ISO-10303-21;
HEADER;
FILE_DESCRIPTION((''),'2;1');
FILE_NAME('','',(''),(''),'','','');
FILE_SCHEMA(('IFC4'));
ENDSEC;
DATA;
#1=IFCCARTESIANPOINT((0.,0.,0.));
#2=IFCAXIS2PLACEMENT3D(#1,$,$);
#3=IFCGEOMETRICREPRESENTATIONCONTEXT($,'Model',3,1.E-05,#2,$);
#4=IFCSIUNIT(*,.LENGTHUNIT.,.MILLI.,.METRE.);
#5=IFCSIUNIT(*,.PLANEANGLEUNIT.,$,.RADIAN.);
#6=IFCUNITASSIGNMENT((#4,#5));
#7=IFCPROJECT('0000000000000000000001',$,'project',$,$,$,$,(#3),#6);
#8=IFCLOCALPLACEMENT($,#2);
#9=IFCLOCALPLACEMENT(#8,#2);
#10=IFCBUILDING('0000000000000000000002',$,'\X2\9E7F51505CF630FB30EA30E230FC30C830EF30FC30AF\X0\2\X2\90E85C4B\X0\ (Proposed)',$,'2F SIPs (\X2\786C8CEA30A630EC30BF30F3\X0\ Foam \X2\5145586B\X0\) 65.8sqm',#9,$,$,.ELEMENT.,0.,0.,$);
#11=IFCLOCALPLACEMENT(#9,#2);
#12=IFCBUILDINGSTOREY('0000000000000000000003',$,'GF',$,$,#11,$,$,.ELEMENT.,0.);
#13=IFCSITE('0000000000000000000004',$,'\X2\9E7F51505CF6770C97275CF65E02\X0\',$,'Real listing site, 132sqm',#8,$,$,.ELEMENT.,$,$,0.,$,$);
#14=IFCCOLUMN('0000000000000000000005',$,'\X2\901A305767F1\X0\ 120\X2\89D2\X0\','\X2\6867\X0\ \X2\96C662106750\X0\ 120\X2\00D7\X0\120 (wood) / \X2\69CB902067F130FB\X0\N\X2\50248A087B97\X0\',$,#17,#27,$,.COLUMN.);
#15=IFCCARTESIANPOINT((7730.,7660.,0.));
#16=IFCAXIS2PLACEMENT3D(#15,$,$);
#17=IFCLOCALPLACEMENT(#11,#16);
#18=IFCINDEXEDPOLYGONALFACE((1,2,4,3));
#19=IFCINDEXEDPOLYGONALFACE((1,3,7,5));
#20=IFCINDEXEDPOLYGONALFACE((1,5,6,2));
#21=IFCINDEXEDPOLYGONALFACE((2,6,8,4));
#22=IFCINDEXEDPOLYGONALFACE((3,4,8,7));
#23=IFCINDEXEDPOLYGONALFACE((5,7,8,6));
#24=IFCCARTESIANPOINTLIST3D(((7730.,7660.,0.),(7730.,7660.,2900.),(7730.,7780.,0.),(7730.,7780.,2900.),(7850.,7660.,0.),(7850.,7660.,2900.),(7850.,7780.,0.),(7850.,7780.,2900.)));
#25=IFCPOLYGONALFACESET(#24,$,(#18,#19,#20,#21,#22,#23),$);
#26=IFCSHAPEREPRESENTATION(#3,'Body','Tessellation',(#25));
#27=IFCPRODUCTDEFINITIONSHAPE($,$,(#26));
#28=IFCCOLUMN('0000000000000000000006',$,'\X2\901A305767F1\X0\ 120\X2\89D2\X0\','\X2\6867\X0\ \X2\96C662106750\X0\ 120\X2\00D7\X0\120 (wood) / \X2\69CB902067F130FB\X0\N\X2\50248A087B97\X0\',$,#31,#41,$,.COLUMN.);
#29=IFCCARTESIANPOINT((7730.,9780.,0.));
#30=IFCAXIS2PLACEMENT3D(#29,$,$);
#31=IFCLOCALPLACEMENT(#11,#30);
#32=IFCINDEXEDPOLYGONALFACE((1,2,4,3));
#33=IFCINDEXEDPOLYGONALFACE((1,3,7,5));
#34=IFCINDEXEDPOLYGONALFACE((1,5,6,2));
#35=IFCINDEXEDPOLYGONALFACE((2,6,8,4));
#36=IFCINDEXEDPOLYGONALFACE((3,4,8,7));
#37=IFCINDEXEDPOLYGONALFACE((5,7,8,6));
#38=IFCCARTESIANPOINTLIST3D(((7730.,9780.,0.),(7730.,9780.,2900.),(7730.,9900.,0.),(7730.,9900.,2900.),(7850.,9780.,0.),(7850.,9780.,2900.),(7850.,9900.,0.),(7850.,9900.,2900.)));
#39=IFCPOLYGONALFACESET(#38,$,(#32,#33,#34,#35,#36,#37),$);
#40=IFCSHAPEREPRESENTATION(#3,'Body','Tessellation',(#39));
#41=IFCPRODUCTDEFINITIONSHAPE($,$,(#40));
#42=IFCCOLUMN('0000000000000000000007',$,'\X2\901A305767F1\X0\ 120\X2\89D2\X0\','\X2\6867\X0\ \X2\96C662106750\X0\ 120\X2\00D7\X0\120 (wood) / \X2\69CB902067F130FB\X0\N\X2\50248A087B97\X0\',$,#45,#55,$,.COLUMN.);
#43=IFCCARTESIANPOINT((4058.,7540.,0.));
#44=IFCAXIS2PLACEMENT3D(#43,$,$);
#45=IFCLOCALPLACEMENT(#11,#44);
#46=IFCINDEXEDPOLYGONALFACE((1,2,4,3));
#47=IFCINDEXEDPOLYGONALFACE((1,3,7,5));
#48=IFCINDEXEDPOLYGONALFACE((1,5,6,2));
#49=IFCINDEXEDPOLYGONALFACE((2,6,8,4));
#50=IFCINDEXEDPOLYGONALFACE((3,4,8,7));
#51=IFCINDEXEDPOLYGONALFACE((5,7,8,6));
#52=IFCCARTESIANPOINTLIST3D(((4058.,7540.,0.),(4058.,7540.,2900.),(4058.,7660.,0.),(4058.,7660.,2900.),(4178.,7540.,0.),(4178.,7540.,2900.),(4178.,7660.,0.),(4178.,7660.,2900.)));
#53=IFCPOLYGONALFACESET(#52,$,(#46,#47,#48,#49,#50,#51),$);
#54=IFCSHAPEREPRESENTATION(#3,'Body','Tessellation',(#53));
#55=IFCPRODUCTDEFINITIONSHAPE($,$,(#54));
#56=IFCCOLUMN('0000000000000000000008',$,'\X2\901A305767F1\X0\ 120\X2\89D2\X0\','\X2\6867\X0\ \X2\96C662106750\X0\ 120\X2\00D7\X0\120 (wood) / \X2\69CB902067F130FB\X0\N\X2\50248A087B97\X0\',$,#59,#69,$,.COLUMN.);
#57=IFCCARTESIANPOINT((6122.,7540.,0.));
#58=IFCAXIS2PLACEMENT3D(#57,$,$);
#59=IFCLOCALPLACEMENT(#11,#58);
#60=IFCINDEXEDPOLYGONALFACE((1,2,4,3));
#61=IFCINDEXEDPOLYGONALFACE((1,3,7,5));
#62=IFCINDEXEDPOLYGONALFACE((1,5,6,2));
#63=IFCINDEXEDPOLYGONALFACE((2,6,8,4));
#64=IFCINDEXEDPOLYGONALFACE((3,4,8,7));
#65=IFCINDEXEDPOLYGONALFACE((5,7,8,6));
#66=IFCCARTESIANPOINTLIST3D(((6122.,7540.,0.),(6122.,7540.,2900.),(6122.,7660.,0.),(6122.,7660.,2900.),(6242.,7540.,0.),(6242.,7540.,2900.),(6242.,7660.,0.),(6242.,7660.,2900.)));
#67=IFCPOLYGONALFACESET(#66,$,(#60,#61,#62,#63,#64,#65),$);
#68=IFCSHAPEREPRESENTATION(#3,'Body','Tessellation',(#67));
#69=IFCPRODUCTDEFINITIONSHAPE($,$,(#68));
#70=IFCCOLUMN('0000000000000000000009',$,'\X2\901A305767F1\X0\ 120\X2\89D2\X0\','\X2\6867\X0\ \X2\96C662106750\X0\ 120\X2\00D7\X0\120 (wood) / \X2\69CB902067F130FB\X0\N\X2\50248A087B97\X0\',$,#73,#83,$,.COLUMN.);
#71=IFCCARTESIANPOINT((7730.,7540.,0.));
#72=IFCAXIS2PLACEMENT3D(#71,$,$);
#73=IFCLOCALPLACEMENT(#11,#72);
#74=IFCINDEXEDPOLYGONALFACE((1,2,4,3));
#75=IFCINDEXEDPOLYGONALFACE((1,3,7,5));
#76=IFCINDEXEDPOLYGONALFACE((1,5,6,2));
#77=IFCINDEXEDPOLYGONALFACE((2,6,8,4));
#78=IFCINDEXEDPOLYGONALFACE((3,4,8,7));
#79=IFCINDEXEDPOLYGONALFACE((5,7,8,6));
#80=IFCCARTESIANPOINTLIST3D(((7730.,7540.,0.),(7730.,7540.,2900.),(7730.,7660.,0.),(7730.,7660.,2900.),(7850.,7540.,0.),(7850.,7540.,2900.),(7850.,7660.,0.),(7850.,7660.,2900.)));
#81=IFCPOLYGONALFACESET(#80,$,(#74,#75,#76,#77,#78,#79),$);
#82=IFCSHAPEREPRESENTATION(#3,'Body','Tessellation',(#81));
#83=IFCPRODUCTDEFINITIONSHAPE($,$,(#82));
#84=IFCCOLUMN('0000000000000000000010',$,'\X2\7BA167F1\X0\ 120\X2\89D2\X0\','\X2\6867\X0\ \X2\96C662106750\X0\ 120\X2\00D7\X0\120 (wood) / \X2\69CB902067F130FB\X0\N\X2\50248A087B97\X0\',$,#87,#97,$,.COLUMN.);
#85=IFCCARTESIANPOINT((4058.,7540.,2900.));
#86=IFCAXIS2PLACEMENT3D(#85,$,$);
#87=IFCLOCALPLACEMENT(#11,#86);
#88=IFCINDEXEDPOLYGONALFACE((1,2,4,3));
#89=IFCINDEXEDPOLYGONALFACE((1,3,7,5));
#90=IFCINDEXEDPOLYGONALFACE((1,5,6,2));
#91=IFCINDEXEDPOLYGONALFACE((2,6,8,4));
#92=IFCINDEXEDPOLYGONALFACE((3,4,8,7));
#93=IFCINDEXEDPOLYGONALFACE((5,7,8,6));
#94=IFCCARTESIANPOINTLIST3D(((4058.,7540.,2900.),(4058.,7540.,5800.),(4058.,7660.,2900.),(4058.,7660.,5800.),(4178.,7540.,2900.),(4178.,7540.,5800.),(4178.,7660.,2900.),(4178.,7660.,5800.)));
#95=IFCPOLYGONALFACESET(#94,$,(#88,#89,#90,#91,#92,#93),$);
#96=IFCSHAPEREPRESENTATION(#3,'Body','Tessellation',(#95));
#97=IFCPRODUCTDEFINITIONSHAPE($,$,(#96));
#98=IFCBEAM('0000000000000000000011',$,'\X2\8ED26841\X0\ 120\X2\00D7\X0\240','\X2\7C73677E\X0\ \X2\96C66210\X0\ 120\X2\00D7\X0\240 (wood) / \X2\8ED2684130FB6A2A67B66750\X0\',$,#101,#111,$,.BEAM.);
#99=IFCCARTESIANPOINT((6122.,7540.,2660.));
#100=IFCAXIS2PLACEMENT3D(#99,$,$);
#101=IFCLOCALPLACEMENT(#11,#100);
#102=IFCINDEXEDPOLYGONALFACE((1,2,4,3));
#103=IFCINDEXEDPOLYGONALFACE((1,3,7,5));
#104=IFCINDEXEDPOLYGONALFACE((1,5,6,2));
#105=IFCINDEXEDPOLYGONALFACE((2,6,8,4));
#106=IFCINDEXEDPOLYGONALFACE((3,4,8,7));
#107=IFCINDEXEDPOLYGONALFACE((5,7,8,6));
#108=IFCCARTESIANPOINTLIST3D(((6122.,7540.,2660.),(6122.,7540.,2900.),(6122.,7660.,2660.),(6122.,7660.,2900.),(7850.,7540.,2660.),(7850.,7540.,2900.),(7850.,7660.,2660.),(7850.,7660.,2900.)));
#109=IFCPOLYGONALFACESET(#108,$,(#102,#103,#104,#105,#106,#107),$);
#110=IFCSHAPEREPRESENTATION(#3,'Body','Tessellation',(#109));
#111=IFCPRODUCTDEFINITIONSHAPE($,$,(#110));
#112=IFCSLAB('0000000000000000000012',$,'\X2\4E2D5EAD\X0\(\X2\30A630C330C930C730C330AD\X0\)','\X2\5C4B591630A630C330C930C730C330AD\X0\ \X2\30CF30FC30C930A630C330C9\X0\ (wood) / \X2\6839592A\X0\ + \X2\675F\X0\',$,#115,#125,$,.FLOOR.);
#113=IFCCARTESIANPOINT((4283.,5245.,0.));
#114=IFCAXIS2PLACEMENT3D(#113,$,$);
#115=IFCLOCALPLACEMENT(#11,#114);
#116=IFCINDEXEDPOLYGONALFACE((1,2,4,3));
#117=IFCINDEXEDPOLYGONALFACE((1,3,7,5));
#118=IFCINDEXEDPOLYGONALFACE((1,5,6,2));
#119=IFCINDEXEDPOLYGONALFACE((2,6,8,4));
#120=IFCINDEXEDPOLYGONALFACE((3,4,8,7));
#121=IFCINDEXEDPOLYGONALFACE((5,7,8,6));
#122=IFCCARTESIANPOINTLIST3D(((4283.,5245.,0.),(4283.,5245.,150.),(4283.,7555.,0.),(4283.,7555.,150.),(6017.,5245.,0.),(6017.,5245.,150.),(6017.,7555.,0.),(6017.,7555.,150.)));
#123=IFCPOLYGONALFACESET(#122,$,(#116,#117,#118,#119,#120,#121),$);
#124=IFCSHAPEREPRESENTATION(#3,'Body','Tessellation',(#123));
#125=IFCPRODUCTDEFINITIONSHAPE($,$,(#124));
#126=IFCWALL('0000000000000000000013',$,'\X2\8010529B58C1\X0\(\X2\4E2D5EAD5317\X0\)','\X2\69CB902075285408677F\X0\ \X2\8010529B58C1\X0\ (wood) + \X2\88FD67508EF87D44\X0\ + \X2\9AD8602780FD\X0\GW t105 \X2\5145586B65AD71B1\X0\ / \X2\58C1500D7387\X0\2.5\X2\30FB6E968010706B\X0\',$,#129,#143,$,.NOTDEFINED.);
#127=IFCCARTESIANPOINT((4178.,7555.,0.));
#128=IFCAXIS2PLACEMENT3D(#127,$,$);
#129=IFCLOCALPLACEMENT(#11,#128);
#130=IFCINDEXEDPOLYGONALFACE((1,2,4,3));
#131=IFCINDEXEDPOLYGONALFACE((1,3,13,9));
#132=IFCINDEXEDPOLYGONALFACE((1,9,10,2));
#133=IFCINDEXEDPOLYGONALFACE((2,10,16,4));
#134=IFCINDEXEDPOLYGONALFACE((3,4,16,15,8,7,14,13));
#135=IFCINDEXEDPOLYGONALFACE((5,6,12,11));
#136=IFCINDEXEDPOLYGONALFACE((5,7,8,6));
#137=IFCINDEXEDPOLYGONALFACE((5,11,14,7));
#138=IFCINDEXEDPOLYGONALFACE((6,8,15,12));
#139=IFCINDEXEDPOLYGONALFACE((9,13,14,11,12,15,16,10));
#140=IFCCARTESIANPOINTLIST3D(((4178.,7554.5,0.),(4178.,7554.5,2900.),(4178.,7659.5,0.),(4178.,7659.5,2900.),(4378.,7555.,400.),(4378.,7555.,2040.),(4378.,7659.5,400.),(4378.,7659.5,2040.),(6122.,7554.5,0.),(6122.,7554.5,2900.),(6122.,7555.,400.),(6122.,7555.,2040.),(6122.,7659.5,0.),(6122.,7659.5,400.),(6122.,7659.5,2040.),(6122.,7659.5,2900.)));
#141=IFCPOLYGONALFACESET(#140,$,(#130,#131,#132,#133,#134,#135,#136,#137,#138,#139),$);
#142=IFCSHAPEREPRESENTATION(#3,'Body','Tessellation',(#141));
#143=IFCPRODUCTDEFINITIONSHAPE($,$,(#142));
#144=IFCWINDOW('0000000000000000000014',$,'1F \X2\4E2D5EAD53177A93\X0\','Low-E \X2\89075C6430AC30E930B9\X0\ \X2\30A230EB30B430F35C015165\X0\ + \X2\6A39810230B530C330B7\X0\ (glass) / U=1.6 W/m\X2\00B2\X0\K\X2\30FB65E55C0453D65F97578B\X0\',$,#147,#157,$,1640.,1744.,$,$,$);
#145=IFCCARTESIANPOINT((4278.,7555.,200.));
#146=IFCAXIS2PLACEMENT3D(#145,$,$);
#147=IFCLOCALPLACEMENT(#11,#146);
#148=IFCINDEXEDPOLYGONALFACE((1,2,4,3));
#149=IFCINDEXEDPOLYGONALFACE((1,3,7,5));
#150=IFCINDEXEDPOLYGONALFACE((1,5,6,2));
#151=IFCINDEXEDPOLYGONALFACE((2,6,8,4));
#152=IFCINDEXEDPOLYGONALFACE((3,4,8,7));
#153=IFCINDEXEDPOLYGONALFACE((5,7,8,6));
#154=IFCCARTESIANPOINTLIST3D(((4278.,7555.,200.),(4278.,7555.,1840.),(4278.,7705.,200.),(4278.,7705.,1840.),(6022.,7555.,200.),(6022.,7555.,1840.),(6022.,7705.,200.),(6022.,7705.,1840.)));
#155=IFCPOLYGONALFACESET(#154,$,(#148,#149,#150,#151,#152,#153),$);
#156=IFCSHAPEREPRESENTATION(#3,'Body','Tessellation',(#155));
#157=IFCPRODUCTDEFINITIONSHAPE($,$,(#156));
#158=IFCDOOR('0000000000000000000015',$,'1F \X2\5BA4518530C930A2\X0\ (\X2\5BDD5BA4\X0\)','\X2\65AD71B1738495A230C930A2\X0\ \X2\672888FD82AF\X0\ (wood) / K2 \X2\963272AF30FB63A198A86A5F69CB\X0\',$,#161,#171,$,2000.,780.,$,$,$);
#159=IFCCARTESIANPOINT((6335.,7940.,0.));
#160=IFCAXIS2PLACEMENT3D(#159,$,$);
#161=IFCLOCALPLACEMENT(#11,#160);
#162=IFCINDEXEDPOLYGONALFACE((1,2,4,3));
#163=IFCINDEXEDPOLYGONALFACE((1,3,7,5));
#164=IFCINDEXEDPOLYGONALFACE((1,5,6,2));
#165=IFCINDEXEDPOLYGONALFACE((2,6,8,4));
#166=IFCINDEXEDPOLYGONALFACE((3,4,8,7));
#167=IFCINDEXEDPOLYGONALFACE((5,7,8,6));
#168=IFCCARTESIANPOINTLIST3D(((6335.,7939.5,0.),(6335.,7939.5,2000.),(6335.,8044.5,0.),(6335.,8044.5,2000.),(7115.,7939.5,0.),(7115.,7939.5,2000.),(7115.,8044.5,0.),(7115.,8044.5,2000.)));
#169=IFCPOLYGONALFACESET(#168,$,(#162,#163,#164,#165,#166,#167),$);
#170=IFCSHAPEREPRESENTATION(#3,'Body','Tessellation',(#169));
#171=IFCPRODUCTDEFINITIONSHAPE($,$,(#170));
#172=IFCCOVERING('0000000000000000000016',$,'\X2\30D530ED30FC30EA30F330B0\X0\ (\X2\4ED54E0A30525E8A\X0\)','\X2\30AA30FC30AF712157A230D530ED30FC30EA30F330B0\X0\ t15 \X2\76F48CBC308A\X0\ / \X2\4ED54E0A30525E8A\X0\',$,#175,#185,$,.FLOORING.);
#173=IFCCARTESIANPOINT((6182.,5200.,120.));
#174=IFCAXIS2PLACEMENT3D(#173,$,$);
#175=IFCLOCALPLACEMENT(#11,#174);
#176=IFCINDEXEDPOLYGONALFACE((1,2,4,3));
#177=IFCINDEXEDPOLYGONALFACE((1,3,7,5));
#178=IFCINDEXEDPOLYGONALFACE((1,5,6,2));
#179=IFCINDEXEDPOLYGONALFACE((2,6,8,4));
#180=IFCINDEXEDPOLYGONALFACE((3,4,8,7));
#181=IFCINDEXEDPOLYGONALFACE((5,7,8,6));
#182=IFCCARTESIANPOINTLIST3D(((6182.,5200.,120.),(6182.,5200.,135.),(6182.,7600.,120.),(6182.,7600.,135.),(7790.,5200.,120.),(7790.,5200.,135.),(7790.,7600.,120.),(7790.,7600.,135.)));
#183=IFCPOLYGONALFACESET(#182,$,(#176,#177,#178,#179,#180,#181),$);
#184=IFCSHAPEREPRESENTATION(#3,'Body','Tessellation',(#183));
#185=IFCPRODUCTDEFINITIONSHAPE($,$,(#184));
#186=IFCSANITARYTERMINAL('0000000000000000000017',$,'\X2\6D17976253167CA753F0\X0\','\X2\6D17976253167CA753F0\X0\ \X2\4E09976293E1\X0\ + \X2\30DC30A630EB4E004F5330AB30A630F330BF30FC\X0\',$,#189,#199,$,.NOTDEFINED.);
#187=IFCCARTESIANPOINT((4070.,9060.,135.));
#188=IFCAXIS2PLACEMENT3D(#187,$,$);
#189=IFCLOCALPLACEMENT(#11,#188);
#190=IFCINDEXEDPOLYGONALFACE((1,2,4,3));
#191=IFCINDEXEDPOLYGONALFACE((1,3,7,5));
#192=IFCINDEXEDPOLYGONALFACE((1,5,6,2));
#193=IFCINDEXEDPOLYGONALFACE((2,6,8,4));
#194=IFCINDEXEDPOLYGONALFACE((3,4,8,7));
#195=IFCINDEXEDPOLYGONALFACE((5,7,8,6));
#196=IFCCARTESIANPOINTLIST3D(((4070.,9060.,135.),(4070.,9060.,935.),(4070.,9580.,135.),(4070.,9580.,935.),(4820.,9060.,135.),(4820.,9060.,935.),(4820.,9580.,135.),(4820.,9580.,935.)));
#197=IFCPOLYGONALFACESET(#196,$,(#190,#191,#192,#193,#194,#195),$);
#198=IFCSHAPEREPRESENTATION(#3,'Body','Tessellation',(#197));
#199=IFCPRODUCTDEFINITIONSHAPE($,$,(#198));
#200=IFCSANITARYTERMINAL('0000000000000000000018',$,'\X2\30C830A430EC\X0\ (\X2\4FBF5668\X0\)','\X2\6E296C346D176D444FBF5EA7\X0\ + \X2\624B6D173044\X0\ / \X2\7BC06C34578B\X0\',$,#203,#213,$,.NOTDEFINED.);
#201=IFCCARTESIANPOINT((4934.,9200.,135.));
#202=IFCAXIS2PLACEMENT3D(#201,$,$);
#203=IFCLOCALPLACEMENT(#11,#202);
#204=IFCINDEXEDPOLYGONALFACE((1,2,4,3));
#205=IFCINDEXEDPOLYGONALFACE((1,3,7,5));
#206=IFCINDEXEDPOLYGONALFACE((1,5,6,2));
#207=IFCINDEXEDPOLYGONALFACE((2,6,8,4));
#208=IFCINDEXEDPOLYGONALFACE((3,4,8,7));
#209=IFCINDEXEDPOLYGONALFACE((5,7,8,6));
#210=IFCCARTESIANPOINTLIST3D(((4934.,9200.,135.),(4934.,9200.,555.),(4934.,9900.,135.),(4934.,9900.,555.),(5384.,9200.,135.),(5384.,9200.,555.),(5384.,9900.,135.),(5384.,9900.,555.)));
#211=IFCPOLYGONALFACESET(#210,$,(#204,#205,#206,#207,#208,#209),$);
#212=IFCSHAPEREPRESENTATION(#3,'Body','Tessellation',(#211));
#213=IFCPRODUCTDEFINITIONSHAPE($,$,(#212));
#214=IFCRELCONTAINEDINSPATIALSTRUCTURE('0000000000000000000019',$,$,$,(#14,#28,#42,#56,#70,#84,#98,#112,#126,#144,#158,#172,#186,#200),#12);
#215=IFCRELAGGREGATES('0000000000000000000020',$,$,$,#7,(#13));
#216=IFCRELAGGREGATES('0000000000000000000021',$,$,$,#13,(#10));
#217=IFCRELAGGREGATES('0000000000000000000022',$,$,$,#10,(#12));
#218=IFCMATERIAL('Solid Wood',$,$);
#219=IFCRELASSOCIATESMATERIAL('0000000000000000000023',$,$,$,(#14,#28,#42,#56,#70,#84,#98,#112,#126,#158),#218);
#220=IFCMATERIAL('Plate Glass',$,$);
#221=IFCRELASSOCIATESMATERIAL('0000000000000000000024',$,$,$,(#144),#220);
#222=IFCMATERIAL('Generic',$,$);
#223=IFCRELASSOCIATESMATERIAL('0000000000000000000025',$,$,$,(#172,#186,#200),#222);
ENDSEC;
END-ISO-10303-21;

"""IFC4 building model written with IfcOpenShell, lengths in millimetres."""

from ifc_helpers import new_model, si_unit, frame, frame_2d, origin, place, context, project, spatial, rectangle, extrude, material, element, fill, save


model = new_model("IFC4")

# Units and contexts
model_context = context("Model", 3, precision=1e-05, world=origin())
ifc_project = project(units=[si_unit("LENGTHUNIT", "METRE", prefix="MILLI"), si_unit("PLANEANGLEUNIT", "RADIAN")], contexts=[model_context])

# Site, building, storey
site_placement = place(None, origin())
site = spatial("IfcSite", under=ifc_project, at=site_placement, Name="鹿児島県霧島市", ObjectType="Real listing site, 132sqm", CompositionType="ELEMENT", RefElevation=0.0)
building_placement = place(site_placement, origin())
building = spatial("IfcBuilding", under=site, at=building_placement, Name="鹿児島・リモートワーク2部屋 (Proposed)", ObjectType="2F SIPs (硬質ウレタン Foam 充填) 65.8sqm", CompositionType="ELEMENT", ElevationOfRefHeight=0.0, ElevationOfTerrain=0.0)
storey_placement = place(building_placement, origin())
storey = spatial("IfcBuildingStorey", under=building, at=storey_placement, Name="GF", CompositionType="ELEMENT", Elevation=0.0)

# Columns
ifc_material_1 = material(Name="Solid Wood")
column_1_placement = place(storey_placement, frame((7730.0, 7660.0, 0.0)))
element("IfcColumn", 1, at=column_1_placement, inside=storey, material=ifc_material_1, Name="通し柱 120角", Description="桧 集成材 120×120 (wood) / 構造柱・N値計算", PredefinedType="COLUMN", context=model_context, shape_type="SweptSolid", body=[
    extrude(rectangle(XDim=120.0, YDim=120.0, at=frame_2d((60.0, 60.0))), frame((7730.0, 7660.0, 0.0)), (0.0, 0.0, 1.0), 2900.0),
])
column_2_placement = place(storey_placement, frame((7730.0, 9780.0, 0.0)))
element("IfcColumn", 2, at=column_2_placement, inside=storey, material=ifc_material_1, Name="通し柱 120角", Description="桧 集成材 120×120 (wood) / 構造柱・N値計算", PredefinedType="COLUMN", context=model_context, shape_type="SweptSolid", body=[
    extrude(rectangle(XDim=120.0, YDim=120.0, at=frame_2d((60.0, 60.0))), frame((7730.0, 9780.0, 0.0)), (0.0, 0.0, 1.0), 2900.0),
])
column_3_placement = place(storey_placement, frame((4058.0, 7540.0, 0.0)))
element("IfcColumn", 3, at=column_3_placement, inside=storey, material=ifc_material_1, Name="通し柱 120角", Description="桧 集成材 120×120 (wood) / 構造柱・N値計算", PredefinedType="COLUMN", context=model_context, shape_type="SweptSolid", body=[
    extrude(rectangle(XDim=120.0, YDim=120.0, at=frame_2d((60.0, 60.0))), frame((4058.0, 7540.0, 0.0)), (0.0, 0.0, 1.0), 2900.0),
])
column_4_placement = place(storey_placement, frame((6122.0, 7540.0, 0.0)))
element("IfcColumn", 4, at=column_4_placement, inside=storey, material=ifc_material_1, Name="通し柱 120角", Description="桧 集成材 120×120 (wood) / 構造柱・N値計算", PredefinedType="COLUMN", context=model_context, shape_type="SweptSolid", body=[
    extrude(rectangle(XDim=120.0, YDim=120.0, at=frame_2d((60.0, 60.0))), frame((6122.0, 7540.0, 0.0)), (0.0, 0.0, 1.0), 2900.0),
])
column_5_placement = place(storey_placement, frame((7730.0, 7540.0, 0.0)))
element("IfcColumn", 5, at=column_5_placement, inside=storey, material=ifc_material_1, Name="通し柱 120角", Description="桧 集成材 120×120 (wood) / 構造柱・N値計算", PredefinedType="COLUMN", context=model_context, shape_type="SweptSolid", body=[
    extrude(rectangle(XDim=120.0, YDim=120.0, at=frame_2d((60.0, 60.0))), frame((7730.0, 7540.0, 0.0)), (0.0, 0.0, 1.0), 2900.0),
])
column_6_placement = place(storey_placement, frame((4058.0, 7540.0, 2900.0)))
element("IfcColumn", 6, at=column_6_placement, inside=storey, material=ifc_material_1, Name="管柱 120角", Description="桧 集成材 120×120 (wood) / 構造柱・N値計算", PredefinedType="COLUMN", context=model_context, shape_type="SweptSolid", body=[
    extrude(rectangle(XDim=120.0, YDim=120.0, at=frame_2d((60.0, 60.0))), frame((4058.0, 7540.0, 2900.0)), (0.0, 0.0, 1.0), 2900.0),
])

# Beam
beam_1_placement = place(storey_placement, frame((6122.0, 7540.0, 2660.0)))
element("IfcBeam", 7, at=beam_1_placement, inside=storey, material=ifc_material_1, Name="軒桁 120×240", Description="米松 集成 120×240 (wood) / 軒桁・横架材", PredefinedType="BEAM", context=model_context, shape_type="SweptSolid", body=[
    extrude(rectangle(XDim=1728.0, YDim=120.0, at=frame_2d((864.0, 60.0))), frame((6122.0, 7540.0, 2660.0)), (0.0, 0.0, 1.0), 240.0),
])

# Slab
slab_placement = place(storey_placement, frame((4283.0, 5245.0, 0.0)))
element("IfcSlab", 8, at=slab_placement, inside=storey, material=ifc_material_1, Name="中庭(ウッドデッキ)", Description="屋外ウッドデッキ ハードウッド (wood) / 根太 + 束", PredefinedType="FLOOR", context=model_context, shape_type="SweptSolid", body=[
    extrude(rectangle(XDim=1734.0, YDim=2310.0, at=frame_2d((867.0, 1155.0))), frame((4283.0, 5245.0, 0.0)), (0.0, 0.0, 1.0), 150.0),
])

# Wall, opening, window
wall_1_placement = place(storey_placement, frame((4178.0, 7555.0, 0.0)))
wall_1 = element("IfcWall", 9, at=wall_1_placement, inside=storey, material=ifc_material_1, Name="耐力壁(中庭北)", Description="構造用合板 耐力壁 (wood) + 製材軸組 + 高性能GW t105 充填断熱 / 壁倍率2.5・準耐火", PredefinedType="NOTDEFINED", context=model_context, shape_type="SweptSolid", body=[
    extrude(rectangle(XDim=1944.0, YDim=105.0, at=frame_2d((972.0, 52.0))), frame((4178.0, 7555.0, 0.0)), (0.0, 0.0, 1.0), 2900.0),
])
opening_placement = place(storey_placement, frame((4278.0, 7555.0, 200.0)))
opening = element("IfcOpeningElement", 10, at=opening_placement, cuts=wall_1, PredefinedType="NOTDEFINED", context=model_context, shape_type="SweptSolid", body=[
    extrude(rectangle(XDim=1744.0, YDim=150.0, at=frame_2d((872.0, 75.0))), frame((4278.0, 7555.0, 200.0)), (0.0, 0.0, 1.0), 1640.0),
])
ifc_material_2 = material(Name="Plate Glass")
window_placement = place(storey_placement, frame((4278.0, 7555.0, 200.0)))
window = element("IfcWindow", 11, at=window_placement, inside=storey, material=ifc_material_2, Name="1F 中庭北窓", Description="Low-E 複層ガラス アルゴン封入 + 樹脂サッシ (glass) / U=1.6 W/m²K・日射取得型", OverallHeight=1640.0, OverallWidth=1744.0, context=model_context, shape_type="SweptSolid", body=[
    extrude(rectangle(XDim=1744.0, YDim=150.0, at=frame_2d((872.0, 75.0))), frame((4278.0, 7555.0, 200.0)), (0.0, 0.0, 1.0), 1640.0),
])
fill(opening, window)

# Door
door_placement = place(storey_placement, frame((6335.0, 7940.0, 0.0)))
element("IfcDoor", 12, at=door_placement, inside=storey, material=ifc_material_1, Name="1F 室内ドア (寝室)", Description="断熱玄関ドア 木製芯 (wood) / K2 防犯・採風機構", OverallHeight=2000.0, OverallWidth=780.0, context=model_context, shape_type="SweptSolid", body=[
    extrude(rectangle(XDim=780.0, YDim=105.0, at=frame_2d((390.0, 52.0))), frame((6335.0, 7940.0, 0.0)), (0.0, 0.0, 1.0), 2000.0),
])

# Covering
ifc_material_3 = material(Name="Generic")
covering_placement = place(storey_placement, frame((6182.0, 5200.0, 120.0)))
element("IfcCovering", 13, at=covering_placement, inside=storey, material=ifc_material_3, Name="フローリング (仕上げ床)", Description="オーク無垢フローリング t15 直貼り / 仕上げ床", PredefinedType="FLOORING", context=model_context, shape_type="SweptSolid", body=[
    extrude(rectangle(XDim=1608.0, YDim=2400.0, at=frame_2d((804.0, 1200.0))), frame((6182.0, 5200.0, 120.0)), (0.0, 0.0, 1.0), 15.0),
])

# Sanitary terminals
sanitary_terminal_1_placement = place(storey_placement, frame((4070.0, 9060.0, 135.0)))
element("IfcSanitaryTerminal", 14, at=sanitary_terminal_1_placement, inside=storey, material=ifc_material_3, Name="洗面化粧台", Description="洗面化粧台 三面鏡 + ボウル一体カウンター", PredefinedType="NOTDEFINED", context=model_context, shape_type="SweptSolid", body=[
    extrude(rectangle(XDim=750.0, YDim=520.0, at=frame_2d((375.0, 260.0))), frame((4070.0, 9060.0, 135.0)), (0.0, 0.0, 1.0), 800.0),
])
sanitary_terminal_2_placement = place(storey_placement, frame((4934.0, 9200.0, 135.0)))
element("IfcSanitaryTerminal", 15, at=sanitary_terminal_2_placement, inside=storey, material=ifc_material_3, Name="トイレ (便器)", Description="温水洗浄便座 + 手洗い / 節水型", PredefinedType="NOTDEFINED", context=model_context, shape_type="SweptSolid", body=[
    extrude(rectangle(XDim=450.0, YDim=700.0, at=frame_2d((225.0, 350.0))), frame((4934.0, 9200.0, 135.0)), (0.0, 0.0, 1.0), 420.0),
])

save(model, "model.ifc")
